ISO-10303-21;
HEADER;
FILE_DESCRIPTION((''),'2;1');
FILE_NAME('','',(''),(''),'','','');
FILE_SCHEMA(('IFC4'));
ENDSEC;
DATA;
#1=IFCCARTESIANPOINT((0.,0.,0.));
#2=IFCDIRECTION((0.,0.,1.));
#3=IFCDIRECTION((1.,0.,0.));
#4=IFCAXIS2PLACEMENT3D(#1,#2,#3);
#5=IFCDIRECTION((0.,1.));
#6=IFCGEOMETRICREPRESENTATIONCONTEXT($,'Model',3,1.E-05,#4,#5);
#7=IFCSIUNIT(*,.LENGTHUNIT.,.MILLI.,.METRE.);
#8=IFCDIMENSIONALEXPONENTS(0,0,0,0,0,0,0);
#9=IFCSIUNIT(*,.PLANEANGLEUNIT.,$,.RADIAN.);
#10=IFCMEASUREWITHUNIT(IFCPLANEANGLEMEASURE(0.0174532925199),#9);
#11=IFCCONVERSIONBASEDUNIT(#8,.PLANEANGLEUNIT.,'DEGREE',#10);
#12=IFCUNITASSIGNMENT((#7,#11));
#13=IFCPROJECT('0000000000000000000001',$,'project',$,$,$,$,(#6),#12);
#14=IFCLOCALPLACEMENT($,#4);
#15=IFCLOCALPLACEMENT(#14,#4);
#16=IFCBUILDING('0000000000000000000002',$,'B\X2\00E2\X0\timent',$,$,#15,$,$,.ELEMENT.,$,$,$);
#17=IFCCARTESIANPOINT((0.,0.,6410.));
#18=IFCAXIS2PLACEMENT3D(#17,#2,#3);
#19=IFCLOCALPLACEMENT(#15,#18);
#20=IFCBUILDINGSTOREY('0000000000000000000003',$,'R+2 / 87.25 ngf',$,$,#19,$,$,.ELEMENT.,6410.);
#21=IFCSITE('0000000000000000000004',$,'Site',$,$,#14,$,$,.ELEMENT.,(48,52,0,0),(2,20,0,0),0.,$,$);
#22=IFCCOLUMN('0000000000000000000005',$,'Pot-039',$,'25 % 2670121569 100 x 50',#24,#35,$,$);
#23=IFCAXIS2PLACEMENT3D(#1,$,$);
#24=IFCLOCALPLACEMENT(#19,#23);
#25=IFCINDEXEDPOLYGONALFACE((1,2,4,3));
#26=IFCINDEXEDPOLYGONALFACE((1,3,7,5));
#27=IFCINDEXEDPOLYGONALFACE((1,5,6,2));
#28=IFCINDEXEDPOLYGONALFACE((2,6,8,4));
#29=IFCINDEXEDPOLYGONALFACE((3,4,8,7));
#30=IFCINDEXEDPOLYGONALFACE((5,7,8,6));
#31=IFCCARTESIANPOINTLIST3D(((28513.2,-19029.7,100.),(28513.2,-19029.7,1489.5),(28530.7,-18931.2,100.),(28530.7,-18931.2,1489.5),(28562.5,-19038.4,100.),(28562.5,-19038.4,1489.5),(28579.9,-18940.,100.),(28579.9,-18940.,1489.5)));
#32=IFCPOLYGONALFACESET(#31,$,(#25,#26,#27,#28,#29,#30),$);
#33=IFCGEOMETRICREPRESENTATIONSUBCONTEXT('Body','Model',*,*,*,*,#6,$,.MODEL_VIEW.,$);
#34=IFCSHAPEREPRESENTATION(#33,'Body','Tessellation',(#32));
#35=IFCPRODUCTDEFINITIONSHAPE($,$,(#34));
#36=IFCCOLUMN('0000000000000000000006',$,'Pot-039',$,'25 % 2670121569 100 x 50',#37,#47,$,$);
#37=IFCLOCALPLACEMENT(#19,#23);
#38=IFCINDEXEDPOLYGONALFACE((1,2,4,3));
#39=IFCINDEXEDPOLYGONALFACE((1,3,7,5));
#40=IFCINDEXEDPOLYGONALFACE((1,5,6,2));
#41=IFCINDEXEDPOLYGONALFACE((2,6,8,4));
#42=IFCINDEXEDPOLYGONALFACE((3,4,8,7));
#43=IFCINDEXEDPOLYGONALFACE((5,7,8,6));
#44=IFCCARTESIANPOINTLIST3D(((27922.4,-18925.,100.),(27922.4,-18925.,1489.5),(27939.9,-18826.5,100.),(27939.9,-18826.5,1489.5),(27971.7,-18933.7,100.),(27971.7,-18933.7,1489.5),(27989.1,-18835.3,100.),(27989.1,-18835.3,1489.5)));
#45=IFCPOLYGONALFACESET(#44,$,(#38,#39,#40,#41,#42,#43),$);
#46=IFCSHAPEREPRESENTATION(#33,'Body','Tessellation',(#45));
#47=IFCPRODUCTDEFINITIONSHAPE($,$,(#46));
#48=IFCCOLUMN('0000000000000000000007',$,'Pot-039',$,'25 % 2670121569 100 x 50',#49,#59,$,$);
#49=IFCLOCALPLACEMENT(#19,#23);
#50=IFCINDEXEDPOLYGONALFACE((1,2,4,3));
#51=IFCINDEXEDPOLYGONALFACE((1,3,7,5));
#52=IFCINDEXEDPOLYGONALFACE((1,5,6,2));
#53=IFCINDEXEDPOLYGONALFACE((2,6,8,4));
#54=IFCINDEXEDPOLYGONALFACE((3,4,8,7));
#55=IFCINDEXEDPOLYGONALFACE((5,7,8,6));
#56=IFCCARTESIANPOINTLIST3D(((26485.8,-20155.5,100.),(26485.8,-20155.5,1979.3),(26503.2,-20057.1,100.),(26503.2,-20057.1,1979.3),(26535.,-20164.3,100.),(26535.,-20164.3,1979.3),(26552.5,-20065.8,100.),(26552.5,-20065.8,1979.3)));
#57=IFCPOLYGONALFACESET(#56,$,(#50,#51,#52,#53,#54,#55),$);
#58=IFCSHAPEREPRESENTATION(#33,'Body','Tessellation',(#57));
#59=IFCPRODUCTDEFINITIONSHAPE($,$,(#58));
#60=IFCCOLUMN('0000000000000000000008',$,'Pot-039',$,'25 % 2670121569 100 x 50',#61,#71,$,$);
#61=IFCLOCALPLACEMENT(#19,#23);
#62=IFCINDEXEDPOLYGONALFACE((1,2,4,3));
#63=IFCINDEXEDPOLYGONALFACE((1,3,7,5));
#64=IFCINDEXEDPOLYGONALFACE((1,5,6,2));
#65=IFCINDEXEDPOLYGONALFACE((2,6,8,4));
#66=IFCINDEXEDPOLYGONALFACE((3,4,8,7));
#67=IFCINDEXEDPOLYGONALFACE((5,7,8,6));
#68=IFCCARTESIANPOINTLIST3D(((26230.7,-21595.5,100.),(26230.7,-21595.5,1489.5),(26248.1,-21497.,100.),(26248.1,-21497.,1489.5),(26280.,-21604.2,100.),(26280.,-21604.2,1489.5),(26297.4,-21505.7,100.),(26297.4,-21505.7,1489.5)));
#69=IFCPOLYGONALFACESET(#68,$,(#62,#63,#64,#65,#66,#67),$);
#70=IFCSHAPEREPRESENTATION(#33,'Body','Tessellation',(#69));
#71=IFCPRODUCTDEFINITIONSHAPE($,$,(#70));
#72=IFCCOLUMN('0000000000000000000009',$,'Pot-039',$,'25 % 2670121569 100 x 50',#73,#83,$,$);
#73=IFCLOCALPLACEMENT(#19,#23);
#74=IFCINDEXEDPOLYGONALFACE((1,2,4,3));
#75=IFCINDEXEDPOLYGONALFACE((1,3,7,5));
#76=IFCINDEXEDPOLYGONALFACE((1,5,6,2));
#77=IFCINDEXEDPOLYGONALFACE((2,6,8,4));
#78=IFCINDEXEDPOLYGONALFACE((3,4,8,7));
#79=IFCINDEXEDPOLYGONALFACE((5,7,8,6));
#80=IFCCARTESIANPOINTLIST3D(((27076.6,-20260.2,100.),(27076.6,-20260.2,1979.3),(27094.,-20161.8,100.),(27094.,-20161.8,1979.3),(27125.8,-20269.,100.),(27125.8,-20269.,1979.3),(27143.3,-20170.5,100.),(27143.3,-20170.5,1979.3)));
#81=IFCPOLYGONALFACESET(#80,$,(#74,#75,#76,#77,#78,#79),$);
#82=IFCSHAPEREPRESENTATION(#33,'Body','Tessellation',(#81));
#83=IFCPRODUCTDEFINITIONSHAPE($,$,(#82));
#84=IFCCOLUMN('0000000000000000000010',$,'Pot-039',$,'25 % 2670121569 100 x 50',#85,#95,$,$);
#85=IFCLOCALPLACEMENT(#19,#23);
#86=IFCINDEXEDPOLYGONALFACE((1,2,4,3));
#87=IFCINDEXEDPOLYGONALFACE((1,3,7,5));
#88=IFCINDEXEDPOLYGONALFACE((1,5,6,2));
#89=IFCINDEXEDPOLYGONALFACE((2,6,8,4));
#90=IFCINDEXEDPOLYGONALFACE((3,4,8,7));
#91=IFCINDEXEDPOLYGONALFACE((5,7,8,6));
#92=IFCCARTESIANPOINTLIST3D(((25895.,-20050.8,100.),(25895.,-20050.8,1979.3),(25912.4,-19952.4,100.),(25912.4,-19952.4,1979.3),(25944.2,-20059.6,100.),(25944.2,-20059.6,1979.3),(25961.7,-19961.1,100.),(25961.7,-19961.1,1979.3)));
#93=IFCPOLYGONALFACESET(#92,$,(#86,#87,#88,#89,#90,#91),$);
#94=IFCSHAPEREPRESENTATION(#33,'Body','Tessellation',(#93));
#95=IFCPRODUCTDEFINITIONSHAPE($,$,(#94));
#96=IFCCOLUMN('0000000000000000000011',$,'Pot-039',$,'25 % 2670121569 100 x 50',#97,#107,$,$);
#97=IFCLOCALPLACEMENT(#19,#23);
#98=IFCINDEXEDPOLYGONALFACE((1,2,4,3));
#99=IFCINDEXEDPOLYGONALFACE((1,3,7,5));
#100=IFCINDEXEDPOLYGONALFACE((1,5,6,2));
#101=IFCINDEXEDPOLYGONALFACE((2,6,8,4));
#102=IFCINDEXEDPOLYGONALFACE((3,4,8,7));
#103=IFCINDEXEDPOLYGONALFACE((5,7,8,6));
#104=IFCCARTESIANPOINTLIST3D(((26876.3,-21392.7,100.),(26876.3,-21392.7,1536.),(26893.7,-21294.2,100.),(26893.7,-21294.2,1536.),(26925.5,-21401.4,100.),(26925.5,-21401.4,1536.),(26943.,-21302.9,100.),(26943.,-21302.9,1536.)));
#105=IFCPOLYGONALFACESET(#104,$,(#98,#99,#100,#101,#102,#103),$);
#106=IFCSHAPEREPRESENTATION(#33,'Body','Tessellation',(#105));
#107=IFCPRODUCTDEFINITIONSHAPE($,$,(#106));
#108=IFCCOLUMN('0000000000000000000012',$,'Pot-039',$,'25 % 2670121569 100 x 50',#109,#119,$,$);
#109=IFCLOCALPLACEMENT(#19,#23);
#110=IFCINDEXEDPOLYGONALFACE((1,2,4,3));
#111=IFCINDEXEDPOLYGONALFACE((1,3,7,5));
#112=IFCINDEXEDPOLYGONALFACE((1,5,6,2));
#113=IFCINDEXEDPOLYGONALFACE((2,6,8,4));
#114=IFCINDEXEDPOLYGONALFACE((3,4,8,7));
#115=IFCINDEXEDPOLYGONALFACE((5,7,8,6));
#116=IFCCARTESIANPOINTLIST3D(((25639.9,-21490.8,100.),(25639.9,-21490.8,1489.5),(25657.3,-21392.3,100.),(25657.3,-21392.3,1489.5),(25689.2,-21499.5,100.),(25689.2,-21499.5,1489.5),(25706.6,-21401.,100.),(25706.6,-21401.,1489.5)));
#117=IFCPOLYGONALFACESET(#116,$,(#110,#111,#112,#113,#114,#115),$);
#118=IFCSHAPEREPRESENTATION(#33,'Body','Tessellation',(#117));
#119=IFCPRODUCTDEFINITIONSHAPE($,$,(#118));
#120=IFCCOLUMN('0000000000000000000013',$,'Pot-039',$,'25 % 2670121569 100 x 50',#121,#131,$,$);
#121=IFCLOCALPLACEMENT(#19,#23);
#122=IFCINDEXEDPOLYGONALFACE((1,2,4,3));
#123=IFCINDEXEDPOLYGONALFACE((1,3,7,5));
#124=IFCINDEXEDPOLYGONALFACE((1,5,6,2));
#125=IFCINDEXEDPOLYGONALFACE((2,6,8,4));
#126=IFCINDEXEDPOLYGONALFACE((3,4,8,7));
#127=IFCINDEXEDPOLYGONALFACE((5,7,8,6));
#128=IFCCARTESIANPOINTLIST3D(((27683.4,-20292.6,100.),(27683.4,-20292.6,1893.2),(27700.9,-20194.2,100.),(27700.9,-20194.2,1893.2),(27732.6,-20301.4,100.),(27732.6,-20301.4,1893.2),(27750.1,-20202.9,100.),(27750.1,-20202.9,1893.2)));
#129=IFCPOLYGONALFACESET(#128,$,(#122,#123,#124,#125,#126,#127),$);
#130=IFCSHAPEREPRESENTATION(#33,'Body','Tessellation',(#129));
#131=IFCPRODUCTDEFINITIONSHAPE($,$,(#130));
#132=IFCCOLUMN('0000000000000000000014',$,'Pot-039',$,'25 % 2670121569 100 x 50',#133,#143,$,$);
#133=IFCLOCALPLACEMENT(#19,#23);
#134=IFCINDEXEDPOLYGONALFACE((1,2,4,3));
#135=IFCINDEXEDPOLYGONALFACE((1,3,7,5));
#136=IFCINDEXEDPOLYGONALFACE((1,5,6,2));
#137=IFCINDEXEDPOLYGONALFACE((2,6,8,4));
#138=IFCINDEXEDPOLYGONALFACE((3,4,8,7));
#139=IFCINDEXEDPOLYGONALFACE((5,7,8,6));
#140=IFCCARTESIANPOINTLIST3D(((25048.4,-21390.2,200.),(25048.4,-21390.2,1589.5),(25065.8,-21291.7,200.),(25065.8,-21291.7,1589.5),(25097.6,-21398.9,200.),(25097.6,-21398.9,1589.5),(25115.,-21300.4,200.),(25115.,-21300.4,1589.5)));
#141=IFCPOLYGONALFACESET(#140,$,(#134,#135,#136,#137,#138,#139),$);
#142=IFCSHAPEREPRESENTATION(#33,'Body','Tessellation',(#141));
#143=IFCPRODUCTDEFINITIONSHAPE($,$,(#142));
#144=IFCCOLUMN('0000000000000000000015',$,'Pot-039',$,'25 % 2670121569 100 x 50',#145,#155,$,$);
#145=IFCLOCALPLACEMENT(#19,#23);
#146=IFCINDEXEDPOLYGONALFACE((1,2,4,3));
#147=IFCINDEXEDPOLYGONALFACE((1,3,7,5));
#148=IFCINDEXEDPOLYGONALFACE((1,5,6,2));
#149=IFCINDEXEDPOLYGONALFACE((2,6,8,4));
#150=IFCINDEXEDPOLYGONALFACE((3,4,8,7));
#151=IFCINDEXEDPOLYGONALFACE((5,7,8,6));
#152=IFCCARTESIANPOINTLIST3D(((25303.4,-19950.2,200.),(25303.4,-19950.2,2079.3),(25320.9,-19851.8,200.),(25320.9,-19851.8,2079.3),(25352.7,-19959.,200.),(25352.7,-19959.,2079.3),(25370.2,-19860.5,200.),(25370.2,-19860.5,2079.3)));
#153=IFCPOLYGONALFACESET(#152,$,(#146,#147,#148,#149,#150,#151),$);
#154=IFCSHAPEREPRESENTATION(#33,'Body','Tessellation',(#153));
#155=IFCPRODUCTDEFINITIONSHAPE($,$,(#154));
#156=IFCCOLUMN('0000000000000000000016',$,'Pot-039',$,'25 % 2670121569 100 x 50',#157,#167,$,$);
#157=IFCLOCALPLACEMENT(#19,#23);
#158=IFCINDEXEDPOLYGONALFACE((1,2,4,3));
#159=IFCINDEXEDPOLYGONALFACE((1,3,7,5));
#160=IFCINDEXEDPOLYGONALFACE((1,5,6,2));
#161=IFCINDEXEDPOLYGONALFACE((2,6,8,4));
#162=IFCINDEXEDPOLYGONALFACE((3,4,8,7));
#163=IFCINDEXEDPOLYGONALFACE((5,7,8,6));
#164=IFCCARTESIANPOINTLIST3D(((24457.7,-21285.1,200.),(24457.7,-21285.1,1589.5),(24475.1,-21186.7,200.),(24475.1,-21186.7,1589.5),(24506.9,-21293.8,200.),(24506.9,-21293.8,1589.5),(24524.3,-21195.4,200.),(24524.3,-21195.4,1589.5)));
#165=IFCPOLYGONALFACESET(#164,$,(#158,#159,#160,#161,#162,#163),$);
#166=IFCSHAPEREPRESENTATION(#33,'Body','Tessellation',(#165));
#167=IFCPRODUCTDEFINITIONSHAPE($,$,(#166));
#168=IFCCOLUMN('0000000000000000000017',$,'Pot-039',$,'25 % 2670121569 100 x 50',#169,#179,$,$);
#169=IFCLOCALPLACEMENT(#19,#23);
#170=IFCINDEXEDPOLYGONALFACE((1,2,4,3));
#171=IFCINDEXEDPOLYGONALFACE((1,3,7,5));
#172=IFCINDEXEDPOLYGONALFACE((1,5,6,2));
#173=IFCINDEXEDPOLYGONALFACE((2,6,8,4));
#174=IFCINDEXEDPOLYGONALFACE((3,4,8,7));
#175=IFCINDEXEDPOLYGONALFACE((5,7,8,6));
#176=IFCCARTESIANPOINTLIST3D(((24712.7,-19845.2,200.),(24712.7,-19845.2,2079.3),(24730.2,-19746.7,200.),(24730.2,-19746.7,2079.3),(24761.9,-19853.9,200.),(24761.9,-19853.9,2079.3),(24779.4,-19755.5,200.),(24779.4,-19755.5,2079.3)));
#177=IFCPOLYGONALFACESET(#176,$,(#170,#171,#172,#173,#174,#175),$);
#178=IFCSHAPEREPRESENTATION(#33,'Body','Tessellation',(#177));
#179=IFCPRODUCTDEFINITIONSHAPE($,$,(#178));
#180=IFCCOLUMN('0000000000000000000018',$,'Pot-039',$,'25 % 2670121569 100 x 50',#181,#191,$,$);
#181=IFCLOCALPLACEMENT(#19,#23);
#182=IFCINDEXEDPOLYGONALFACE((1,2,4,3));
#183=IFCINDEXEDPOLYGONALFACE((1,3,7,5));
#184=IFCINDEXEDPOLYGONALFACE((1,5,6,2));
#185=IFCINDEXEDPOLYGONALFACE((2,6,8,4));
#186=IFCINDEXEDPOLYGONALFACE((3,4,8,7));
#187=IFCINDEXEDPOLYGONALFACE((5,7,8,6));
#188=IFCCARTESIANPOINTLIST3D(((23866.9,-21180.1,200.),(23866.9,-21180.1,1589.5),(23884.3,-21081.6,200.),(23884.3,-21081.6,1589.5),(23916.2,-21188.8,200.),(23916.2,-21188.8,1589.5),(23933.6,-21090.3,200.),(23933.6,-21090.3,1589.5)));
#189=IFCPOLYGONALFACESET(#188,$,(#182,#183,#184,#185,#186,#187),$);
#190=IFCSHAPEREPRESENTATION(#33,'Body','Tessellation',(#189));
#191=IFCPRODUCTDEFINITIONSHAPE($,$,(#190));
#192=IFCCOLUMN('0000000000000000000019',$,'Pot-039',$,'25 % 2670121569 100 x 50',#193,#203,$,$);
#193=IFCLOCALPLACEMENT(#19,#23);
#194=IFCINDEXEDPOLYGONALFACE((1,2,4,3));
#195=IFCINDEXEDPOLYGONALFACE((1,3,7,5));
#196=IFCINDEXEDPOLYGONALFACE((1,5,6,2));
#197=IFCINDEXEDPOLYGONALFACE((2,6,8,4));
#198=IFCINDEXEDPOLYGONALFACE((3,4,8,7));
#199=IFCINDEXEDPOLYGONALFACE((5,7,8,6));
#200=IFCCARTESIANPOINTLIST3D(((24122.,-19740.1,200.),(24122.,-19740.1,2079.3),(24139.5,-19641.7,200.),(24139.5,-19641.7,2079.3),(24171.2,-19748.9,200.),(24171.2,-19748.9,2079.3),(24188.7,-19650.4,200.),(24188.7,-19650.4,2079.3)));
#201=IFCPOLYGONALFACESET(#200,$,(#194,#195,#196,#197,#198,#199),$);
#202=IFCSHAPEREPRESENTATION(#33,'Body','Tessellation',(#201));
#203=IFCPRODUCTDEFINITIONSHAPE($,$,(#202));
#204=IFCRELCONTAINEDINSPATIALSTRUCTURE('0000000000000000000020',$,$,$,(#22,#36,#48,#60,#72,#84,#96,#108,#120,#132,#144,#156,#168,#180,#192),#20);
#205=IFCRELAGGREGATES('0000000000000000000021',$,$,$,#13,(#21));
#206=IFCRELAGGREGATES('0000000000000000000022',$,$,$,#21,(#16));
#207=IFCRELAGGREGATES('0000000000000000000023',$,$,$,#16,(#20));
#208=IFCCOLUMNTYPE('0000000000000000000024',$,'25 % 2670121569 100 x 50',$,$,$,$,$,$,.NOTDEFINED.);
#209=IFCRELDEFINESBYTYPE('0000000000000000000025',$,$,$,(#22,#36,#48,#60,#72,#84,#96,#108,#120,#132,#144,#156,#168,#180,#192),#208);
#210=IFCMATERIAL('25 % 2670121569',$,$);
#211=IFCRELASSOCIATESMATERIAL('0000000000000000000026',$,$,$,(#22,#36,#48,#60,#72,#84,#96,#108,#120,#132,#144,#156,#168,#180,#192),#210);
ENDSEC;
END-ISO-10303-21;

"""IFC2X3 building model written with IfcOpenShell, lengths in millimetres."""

from ifc_helpers import new_model, entity, si_unit, converted_unit, direction, frame, origin_with_axes, origin_2d_with_axis, place, context, subcontext, project, spatial, rectangle, extrude, material, type_object, element, save


model = new_model("IFC2X3")

# Units and contexts
model_context = context("Model", 3, precision=1e-05, world=origin_with_axes(), true_north=direction((0.0, 1.0)))
body_context = subcontext(model_context, "Body", "Model", "MODEL_VIEW")
ifc_project = project(units=[si_unit("LENGTHUNIT", "METRE", prefix="MILLI"), converted_unit("PLANEANGLEUNIT", "DEGREE", entity("IfcPlaneAngleMeasure", 0.0174532925199), si_unit("PLANEANGLEUNIT", "RADIAN"), dimensions=[0, 0, 0, 0, 0, 0, 0])], contexts=[model_context])

# Site, building, storey
site_placement = place(None, origin_with_axes())
site = spatial("IfcSite", under=ifc_project, at=site_placement, Name="Site", CompositionType="ELEMENT", RefLatitude=(48, 52, 0, 0), RefLongitude=(2, 20, 0, 0), RefElevation=0.0)
building_placement = place(site_placement, origin_with_axes())
building = spatial("IfcBuilding", under=site, at=building_placement, Name="Bâtiment", CompositionType="ELEMENT")
storey_placement = place(building_placement, frame((0.0, 0.0, 6410.0), z_axis=(0.0, 0.0, 1.0), x_axis=(1.0, 0.0, 0.0)))
storey = spatial("IfcBuildingStorey", under=building, at=storey_placement, Name="R+2 / 87.25 ngf", CompositionType="ELEMENT", Elevation=6410.0)

# Columns
ifc_material_1 = material(Name="25 % 2670121569")
column_type = type_object("IfcColumnType", Name="25 % 2670121569 100 x 50", PredefinedType="NOTDEFINED")
for number, where, z_axis, x_axis, name in (
    (1, (28546.6, -18984.8, 100.0), (0.0, 0.0, 1.0), (0.17478, 0.984607, 0.0), "Pot-039"),
    (2, (27955.8, -18880.1, 100.0), (0.0, 0.0, 1.0), (0.17478, 0.984607, 0.0), "Pot-039"),
):
    element("IfcColumn", number, at=place(storey_placement, frame(where, z_axis=z_axis, x_axis=x_axis)), inside=storey, type_object=column_type, material=ifc_material_1, Name=name, ObjectType="25 % 2670121569 100 x 50", context=body_context, shape_type="SweptSolid", body=[
        extrude(rectangle(XDim=100.0, YDim=50.0, at=origin_2d_with_axis()), origin_with_axes(), (0.0, 0.0, 1.0), 1389.5),
    ])
column_1_placement = place(storey_placement, frame((26519.1, -20110.7, 100.0), z_axis=(0.0, 0.0, 1.0), x_axis=(0.17478, 0.984607, 0.0)))
element("IfcColumn", 3, at=column_1_placement, inside=storey, type_object=column_type, material=ifc_material_1, Name="Pot-039", ObjectType="25 % 2670121569 100 x 50", context=body_context, shape_type="SweptSolid", body=[
    extrude(rectangle(XDim=100.0, YDim=50.0, at=origin_2d_with_axis()), origin_with_axes(), (0.0, 0.0, 1.0), 1879.3),
])
column_2_placement = place(storey_placement, frame((26264.0, -21550.6, 100.0), z_axis=(0.0, 0.0, 1.0), x_axis=(0.17408, 0.984731, 0.0)))
element("IfcColumn", 4, at=column_2_placement, inside=storey, type_object=column_type, material=ifc_material_1, Name="Pot-039", ObjectType="25 % 2670121569 100 x 50", context=body_context, shape_type="SweptSolid", body=[
    extrude(rectangle(XDim=100.0, YDim=50.0, at=origin_2d_with_axis()), origin_with_axes(), (0.0, 0.0, 1.0), 1389.5),
])
for number, where, z_axis, x_axis, name in (
    (5, (27109.9, -20215.4, 100.0), (0.0, 0.0, 1.0), (0.17478, 0.984607, 0.0), "Pot-039"),
    (6, (25928.3, -20006.0, 100.0), (0.0, 0.0, 1.0), (0.17478, 0.984607, 0.0), "Pot-039"),
):
    element("IfcColumn", number, at=place(storey_placement, frame(where, z_axis=z_axis, x_axis=x_axis)), inside=storey, type_object=column_type, material=ifc_material_1, Name=name, ObjectType="25 % 2670121569 100 x 50", context=body_context, shape_type="SweptSolid", body=[
        extrude(rectangle(XDim=100.0, YDim=50.0, at=origin_2d_with_axis()), origin_with_axes(), (0.0, 0.0, 1.0), 1879.3),
    ])
column_3_placement = place(storey_placement, frame((26909.6, -21347.8, 100.0), z_axis=(0.0, 0.0, 1.0), x_axis=(0.17408, 0.984731, 0.0)))
element("IfcColumn", 7, at=column_3_placement, inside=storey, type_object=column_type, material=ifc_material_1, Name="Pot-039", ObjectType="25 % 2670121569 100 x 50", context=body_context, shape_type="SweptSolid", body=[
    extrude(rectangle(XDim=100.0, YDim=50.0, at=origin_2d_with_axis()), origin_with_axes(), (0.0, 0.0, 1.0), 1436.0),
])
column_4_placement = place(storey_placement, frame((25673.2, -21445.9, 100.0), z_axis=(0.0, 0.0, 1.0), x_axis=(0.17408, 0.984731, 0.0)))
element("IfcColumn", 8, at=column_4_placement, inside=storey, type_object=column_type, material=ifc_material_1, Name="Pot-039", ObjectType="25 % 2670121569 100 x 50", context=body_context, shape_type="SweptSolid", body=[
    extrude(rectangle(XDim=100.0, YDim=50.0, at=origin_2d_with_axis()), origin_with_axes(), (0.0, 0.0, 1.0), 1389.5),
])
column_5_placement = place(storey_placement, frame((27716.7, -20247.8, 100.0), z_axis=(0.0, 0.0, 1.0), x_axis=(0.17478, 0.984607, 0.0)))
element("IfcColumn", 9, at=column_5_placement, inside=storey, type_object=column_type, material=ifc_material_1, Name="Pot-039", ObjectType="25 % 2670121569 100 x 50", context=body_context, shape_type="SweptSolid", body=[
    extrude(rectangle(XDim=100.0, YDim=50.0, at=origin_2d_with_axis()), origin_with_axes(), (0.0, 0.0, 1.0), 1793.2),
])
column_6_placement = place(storey_placement, frame((25081.7, -21345.3, 200.0), z_axis=(0.0, 0.0, 1.0), x_axis=(0.17408, 0.984731, 0.0)))
element("IfcColumn", 10, at=column_6_placement, inside=storey, type_object=column_type, material=ifc_material_1, Name="Pot-039", ObjectType="25 % 2670121569 100 x 50", context=body_context, shape_type="SweptSolid", body=[
    extrude(rectangle(XDim=100.0, YDim=50.0, at=origin_2d_with_axis()), origin_with_axes(), (0.0, 0.0, 1.0), 1389.5),
])
column_7_placement = place(storey_placement, frame((25336.8, -19905.4, 200.0), z_axis=(0.0, 0.0, 1.0), x_axis=(0.17478, 0.984607, 0.0)))
element("IfcColumn", 11, at=column_7_placement, inside=storey, type_object=column_type, material=ifc_material_1, Name="Pot-039", ObjectType="25 % 2670121569 100 x 50", context=body_context, shape_type="SweptSolid", body=[
    extrude(rectangle(XDim=100.0, YDim=50.0, at=origin_2d_with_axis()), origin_with_axes(), (0.0, 0.0, 1.0), 1879.3),
])
column_8_placement = place(storey_placement, frame((24491.0, -21240.3, 200.0), z_axis=(0.0, 0.0, 1.0), x_axis=(0.17408, 0.984731, 0.0)))
element("IfcColumn", 12, at=column_8_placement, inside=storey, type_object=column_type, material=ifc_material_1, Name="Pot-039", ObjectType="25 % 2670121569 100 x 50", context=body_context, shape_type="SweptSolid", body=[
    extrude(rectangle(XDim=100.0, YDim=50.0, at=origin_2d_with_axis()), origin_with_axes(), (0.0, 0.0, 1.0), 1389.5),
])
column_9_placement = place(storey_placement, frame((24746.1, -19800.3, 200.0), z_axis=(0.0, 0.0, 1.0), x_axis=(0.17478, 0.984607, 0.0)))
element("IfcColumn", 13, at=column_9_placement, inside=storey, type_object=column_type, material=ifc_material_1, Name="Pot-039", ObjectType="25 % 2670121569 100 x 50", context=body_context, shape_type="SweptSolid", body=[
    extrude(rectangle(XDim=100.0, YDim=50.0, at=origin_2d_with_axis()), origin_with_axes(), (0.0, 0.0, 1.0), 1879.3),
])
column_10_placement = place(storey_placement, frame((23900.3, -21135.2, 200.0), z_axis=(0.0, 0.0, 1.0), x_axis=(0.17408, 0.984731, 0.0)))
element("IfcColumn", 14, at=column_10_placement, inside=storey, type_object=column_type, material=ifc_material_1, Name="Pot-039", ObjectType="25 % 2670121569 100 x 50", context=body_context, shape_type="SweptSolid", body=[
    extrude(rectangle(XDim=100.0, YDim=50.0, at=origin_2d_with_axis()), origin_with_axes(), (0.0, 0.0, 1.0), 1389.5),
])
column_11_placement = place(storey_placement, frame((24155.3, -19695.3, 200.0), z_axis=(0.0, 0.0, 1.0), x_axis=(0.17478, 0.984607, 0.0)))
element("IfcColumn", 15, at=column_11_placement, inside=storey, type_object=column_type, material=ifc_material_1, Name="Pot-039", ObjectType="25 % 2670121569 100 x 50", context=body_context, shape_type="SweptSolid", body=[
    extrude(rectangle(XDim=100.0, YDim=50.0, at=origin_2d_with_axis()), origin_with_axes(), (0.0, 0.0, 1.0), 1879.3),
])

save(model, "model.ifc")
